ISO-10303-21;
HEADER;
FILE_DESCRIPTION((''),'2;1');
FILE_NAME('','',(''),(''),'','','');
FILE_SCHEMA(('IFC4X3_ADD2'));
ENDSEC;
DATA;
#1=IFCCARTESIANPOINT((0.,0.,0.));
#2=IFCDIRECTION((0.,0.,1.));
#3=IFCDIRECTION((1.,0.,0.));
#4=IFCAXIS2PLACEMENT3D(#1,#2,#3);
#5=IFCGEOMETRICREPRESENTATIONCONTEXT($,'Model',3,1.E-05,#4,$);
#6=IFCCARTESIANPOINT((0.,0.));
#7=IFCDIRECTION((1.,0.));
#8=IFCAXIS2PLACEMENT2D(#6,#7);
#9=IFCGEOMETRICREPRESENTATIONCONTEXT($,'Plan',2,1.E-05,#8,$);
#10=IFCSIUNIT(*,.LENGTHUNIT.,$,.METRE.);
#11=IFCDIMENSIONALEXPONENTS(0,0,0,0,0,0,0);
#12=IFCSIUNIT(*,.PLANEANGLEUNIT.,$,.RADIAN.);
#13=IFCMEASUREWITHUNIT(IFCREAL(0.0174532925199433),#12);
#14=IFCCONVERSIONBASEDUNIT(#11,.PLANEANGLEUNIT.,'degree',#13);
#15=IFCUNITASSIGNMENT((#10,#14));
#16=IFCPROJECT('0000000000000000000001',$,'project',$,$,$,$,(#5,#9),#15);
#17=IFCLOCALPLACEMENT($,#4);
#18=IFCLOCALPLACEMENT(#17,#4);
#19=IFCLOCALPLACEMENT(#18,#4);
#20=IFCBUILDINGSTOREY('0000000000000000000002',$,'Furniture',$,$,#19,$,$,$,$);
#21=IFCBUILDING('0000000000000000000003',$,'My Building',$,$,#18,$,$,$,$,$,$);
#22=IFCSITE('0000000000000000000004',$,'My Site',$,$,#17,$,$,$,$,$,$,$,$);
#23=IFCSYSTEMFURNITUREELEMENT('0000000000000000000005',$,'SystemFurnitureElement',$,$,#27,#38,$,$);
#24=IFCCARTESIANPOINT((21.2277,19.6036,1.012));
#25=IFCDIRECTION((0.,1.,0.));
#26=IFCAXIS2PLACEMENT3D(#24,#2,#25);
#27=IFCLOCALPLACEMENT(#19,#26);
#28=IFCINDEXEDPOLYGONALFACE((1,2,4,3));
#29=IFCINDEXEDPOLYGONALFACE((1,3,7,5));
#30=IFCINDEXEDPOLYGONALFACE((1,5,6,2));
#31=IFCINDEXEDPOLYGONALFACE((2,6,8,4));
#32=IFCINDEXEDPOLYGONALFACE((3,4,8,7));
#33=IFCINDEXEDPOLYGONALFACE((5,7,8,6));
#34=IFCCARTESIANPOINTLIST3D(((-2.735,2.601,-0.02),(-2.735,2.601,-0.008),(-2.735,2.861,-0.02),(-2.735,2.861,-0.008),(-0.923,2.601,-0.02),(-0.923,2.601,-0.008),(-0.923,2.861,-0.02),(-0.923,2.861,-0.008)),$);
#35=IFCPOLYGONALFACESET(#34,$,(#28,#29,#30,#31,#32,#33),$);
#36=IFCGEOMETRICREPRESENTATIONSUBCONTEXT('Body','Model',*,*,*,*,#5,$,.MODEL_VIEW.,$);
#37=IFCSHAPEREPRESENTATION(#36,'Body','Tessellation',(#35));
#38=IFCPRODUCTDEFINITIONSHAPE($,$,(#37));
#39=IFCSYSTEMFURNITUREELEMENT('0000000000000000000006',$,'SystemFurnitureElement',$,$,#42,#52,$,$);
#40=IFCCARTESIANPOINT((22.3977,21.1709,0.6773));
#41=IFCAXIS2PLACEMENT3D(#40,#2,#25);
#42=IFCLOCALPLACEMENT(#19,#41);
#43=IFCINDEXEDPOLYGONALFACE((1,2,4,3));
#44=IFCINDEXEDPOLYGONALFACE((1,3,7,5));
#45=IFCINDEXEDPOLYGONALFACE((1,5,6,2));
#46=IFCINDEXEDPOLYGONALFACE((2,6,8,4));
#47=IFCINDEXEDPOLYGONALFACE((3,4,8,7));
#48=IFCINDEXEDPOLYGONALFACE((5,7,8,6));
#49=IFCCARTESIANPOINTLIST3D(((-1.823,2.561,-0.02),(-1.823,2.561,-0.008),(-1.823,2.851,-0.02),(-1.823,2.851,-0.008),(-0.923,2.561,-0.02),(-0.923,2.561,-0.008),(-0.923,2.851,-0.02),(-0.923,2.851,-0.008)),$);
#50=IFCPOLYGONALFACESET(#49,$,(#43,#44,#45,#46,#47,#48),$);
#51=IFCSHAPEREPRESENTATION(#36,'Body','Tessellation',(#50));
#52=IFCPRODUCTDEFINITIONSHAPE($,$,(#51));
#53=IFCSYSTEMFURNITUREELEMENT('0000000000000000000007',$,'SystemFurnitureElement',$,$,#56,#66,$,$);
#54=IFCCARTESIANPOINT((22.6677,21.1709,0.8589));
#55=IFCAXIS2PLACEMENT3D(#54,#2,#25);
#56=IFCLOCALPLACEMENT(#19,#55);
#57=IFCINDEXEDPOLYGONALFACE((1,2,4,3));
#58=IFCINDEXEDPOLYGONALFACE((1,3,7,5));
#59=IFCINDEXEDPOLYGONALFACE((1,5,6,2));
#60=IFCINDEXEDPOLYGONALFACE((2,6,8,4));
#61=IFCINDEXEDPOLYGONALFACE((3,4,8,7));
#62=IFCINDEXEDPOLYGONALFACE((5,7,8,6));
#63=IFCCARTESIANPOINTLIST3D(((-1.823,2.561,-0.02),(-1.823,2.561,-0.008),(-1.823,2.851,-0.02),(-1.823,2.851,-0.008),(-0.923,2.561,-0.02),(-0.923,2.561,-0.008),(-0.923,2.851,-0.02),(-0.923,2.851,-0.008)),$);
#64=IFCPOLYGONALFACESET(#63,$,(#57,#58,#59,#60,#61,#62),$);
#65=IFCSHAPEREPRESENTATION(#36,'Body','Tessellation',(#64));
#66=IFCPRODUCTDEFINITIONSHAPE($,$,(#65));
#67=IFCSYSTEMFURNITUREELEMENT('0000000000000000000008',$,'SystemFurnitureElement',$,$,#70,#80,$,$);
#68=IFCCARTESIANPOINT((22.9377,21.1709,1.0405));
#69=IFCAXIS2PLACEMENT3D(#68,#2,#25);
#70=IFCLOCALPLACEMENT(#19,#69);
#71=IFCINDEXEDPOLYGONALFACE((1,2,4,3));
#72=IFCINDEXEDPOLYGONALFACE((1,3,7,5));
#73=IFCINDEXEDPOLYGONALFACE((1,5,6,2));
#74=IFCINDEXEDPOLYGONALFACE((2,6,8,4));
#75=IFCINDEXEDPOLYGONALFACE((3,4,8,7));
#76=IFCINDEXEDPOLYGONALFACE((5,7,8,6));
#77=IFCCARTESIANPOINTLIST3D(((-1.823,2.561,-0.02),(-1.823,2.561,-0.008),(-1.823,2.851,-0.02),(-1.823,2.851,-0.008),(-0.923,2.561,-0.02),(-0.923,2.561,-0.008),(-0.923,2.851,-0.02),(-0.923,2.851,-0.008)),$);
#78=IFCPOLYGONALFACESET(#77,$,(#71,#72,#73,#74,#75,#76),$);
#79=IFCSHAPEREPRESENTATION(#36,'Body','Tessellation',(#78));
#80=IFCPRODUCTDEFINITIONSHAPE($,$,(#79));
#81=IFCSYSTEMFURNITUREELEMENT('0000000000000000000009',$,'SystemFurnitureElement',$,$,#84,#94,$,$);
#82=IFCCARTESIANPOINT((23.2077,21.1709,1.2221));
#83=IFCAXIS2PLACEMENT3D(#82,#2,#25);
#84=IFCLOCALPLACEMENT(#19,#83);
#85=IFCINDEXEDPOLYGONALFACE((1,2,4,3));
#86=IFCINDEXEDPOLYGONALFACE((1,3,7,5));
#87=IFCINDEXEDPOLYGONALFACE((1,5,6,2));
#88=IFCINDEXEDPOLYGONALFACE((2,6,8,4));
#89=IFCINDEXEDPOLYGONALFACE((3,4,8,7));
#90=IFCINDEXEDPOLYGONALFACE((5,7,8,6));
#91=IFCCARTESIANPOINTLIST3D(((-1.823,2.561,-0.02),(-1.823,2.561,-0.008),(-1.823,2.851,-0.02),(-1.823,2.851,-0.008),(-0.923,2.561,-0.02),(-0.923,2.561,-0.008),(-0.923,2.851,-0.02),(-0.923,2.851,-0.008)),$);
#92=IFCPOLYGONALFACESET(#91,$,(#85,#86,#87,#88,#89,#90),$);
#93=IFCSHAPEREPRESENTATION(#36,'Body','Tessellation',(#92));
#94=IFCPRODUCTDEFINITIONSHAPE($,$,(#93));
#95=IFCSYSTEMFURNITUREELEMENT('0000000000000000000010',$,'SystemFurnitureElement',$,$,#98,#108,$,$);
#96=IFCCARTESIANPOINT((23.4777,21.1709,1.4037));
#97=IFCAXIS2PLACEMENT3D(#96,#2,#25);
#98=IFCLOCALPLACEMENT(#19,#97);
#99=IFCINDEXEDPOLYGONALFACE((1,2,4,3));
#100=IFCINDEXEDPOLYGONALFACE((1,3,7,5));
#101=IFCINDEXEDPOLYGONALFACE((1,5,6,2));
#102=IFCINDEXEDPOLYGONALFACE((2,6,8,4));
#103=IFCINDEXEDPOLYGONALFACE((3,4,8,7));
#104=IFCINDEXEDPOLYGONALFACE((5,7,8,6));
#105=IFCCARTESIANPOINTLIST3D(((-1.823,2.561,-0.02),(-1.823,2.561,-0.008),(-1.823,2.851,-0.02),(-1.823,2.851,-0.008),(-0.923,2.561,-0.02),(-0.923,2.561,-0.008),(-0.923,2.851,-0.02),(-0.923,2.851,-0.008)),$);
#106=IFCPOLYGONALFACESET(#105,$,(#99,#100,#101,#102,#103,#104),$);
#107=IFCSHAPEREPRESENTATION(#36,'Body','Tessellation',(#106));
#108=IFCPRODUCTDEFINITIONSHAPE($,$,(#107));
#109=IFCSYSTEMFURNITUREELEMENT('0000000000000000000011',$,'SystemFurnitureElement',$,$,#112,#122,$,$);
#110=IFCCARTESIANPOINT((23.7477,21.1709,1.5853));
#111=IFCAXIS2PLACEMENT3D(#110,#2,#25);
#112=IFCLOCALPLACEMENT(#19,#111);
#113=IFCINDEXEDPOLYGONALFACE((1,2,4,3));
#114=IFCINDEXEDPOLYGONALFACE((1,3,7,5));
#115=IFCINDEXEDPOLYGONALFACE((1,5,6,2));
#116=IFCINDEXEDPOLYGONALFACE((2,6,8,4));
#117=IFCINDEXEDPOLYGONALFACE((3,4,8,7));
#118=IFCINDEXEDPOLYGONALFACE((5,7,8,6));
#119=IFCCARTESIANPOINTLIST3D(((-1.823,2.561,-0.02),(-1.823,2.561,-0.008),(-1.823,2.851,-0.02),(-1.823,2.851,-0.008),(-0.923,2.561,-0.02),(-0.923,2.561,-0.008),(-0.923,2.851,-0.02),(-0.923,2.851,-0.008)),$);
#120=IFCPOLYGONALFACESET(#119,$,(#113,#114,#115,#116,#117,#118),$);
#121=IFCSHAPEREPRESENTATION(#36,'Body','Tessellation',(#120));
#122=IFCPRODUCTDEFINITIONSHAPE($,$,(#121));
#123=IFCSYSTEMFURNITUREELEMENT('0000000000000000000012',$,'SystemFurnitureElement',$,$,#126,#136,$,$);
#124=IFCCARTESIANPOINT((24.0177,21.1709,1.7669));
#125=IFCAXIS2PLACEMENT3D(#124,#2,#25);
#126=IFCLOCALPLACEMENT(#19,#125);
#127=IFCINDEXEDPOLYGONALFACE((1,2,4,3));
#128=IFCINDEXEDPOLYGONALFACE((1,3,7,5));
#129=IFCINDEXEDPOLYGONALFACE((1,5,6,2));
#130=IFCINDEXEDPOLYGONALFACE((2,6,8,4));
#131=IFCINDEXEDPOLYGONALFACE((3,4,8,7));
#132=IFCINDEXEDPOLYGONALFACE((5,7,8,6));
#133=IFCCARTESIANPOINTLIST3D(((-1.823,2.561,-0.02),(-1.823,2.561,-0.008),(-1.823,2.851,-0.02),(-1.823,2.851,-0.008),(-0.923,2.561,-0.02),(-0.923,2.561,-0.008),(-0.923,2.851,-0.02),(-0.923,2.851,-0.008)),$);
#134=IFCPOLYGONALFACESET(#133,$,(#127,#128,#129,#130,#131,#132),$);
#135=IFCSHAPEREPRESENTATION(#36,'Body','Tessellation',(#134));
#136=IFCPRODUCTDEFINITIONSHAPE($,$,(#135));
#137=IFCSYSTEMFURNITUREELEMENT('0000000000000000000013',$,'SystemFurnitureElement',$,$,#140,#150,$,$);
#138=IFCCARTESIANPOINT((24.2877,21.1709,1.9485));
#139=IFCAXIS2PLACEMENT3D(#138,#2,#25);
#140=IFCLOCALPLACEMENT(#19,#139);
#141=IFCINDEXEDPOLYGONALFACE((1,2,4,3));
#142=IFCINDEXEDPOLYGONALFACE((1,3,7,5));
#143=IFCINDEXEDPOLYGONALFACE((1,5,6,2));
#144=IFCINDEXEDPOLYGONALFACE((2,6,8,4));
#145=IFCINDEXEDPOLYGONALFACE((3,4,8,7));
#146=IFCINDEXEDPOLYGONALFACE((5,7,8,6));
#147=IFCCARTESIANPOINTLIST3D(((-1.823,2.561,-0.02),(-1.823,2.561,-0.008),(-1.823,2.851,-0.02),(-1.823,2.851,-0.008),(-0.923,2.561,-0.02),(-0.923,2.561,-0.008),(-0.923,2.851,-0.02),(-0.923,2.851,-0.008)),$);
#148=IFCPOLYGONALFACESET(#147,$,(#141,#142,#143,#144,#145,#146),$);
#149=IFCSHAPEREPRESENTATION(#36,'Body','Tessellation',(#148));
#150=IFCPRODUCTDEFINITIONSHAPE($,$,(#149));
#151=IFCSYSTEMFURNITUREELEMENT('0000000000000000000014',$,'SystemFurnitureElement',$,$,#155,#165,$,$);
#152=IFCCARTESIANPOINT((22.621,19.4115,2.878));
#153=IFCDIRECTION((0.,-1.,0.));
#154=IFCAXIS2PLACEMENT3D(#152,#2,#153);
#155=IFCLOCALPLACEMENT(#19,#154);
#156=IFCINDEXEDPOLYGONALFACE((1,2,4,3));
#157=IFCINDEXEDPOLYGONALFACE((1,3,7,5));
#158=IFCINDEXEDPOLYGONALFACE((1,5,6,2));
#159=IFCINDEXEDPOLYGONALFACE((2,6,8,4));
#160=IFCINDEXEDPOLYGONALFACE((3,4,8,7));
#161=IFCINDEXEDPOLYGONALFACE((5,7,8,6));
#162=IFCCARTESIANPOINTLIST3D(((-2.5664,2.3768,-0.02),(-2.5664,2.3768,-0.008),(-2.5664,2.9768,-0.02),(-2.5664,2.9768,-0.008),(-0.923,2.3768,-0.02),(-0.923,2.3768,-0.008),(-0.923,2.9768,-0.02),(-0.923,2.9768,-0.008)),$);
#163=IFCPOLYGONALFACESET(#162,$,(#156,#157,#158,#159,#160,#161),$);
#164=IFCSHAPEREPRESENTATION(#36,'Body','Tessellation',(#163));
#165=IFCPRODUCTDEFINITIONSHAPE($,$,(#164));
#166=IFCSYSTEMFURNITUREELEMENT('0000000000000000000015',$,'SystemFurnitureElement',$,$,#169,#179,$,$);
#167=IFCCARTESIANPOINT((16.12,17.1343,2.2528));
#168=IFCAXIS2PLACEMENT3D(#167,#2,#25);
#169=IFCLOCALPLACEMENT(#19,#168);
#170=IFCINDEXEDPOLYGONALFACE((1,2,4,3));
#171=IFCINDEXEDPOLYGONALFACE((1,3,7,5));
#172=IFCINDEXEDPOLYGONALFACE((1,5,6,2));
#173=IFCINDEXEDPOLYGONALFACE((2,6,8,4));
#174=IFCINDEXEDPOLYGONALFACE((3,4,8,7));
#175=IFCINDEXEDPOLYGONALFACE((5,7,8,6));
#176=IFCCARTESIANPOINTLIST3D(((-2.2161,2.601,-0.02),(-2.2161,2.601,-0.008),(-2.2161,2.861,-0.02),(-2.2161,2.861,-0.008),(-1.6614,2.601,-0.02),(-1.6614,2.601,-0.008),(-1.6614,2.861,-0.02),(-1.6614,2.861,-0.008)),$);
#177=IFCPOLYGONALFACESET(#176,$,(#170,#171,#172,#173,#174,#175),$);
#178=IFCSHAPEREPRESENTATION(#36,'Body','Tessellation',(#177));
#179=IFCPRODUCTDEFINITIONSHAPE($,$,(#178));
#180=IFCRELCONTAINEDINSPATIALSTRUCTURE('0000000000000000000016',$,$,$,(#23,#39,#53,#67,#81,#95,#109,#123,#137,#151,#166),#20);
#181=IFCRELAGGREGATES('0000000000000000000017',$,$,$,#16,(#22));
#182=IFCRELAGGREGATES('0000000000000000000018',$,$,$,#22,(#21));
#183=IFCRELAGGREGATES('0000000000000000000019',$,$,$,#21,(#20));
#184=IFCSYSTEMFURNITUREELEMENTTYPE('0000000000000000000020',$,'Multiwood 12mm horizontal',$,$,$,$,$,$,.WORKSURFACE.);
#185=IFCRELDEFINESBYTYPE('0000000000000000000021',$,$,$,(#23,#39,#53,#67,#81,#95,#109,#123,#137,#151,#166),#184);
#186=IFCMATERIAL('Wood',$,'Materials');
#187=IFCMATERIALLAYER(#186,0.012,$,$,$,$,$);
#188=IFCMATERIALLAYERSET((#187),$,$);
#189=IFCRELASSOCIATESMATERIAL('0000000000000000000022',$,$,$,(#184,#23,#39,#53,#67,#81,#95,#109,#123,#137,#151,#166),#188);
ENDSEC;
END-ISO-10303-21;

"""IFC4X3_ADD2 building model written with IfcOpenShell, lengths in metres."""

from ifc_helpers import new_model, entity, si_unit, converted_unit, frame, origin_with_axes, origin_2d_with_axis, place, context, subcontext, project, spatial, indexed_curve, outline, extrude, material, layer, layer_set, layer_usage, type_object, element, save


model = new_model("IFC4X3_ADD2")

# Units and contexts
model_context = context("Model", 3, precision=1e-05, world=origin_with_axes())
plan_context = context("Plan", 2, precision=1e-05, world=origin_2d_with_axis())
body_context = subcontext(model_context, "Body", "Model", "MODEL_VIEW")
ifc_project = project(units=[si_unit("LENGTHUNIT", "METRE"), converted_unit("PLANEANGLEUNIT", "degree", entity("IfcReal", 0.0174532925199433), si_unit("PLANEANGLEUNIT", "RADIAN"), dimensions=[0, 0, 0, 0, 0, 0, 0])], contexts=[model_context, plan_context])

# Site, building, storey
site_placement = place(None, origin_with_axes())
site = spatial("IfcSite", under=ifc_project, at=site_placement, Name="My Site")
building_placement = place(site_placement, origin_with_axes())
building = spatial("IfcBuilding", under=site, at=building_placement, Name="My Building")
storey_placement = place(building_placement, origin_with_axes())
storey = spatial("IfcBuildingStorey", under=building, at=storey_placement, Name="Furniture")

# System furniture elements
ifc_material = material(Name="Wood", Category="Materials")
ifc_layer_1 = layer(ifc_material, 0.012)
ifc_layer_set_1 = layer_set([ifc_layer_1])
ifc_layer_usage_1 = layer_usage(ifc_layer_set_1, "AXIS3", "POSITIVE", -0.02)
system_furniture_element_type_1 = type_object("IfcSystemFurnitureElementType", Name="Multiwood 12mm horizontal", PredefinedType="WORKSURFACE", material=ifc_layer_set_1)
system_furniture_element_1_placement = place(storey_placement, frame((21.2277, 19.6036, 1.012), z_axis=(0.0, 0.0, 1.0), x_axis=(0.0, 1.0, 0.0)))
element("IfcSystemFurnitureElement", 1, at=system_furniture_element_1_placement, inside=storey, type_object=system_furniture_element_type_1, material=ifc_layer_usage_1, Name="SystemFurnitureElement", context=body_context, shape_type="SweptSolid", body=[
    extrude(outline(indexed_curve([(-2.735, 2.861), (-2.735, 2.601), (-0.923, 2.601), (-0.923, 2.861), (-2.735, 2.861)])), frame((0.0, 0.0, -0.02), z_axis=(0.0, 0.0, 1.0), x_axis=(1.0, 0.0, 0.0)), (0.0, 0.0, 1.0), 0.012),
])
ifc_layer_usage_2 = layer_usage(ifc_layer_set_1, "AXIS3", "POSITIVE", -0.02)
system_furniture_element_2_placement = place(storey_placement, frame((22.3977, 21.1709, 0.6773), z_axis=(0.0, 0.0, 1.0), x_axis=(0.0, 1.0, 0.0)))
element("IfcSystemFurnitureElement", 2, at=system_furniture_element_2_placement, inside=storey, type_object=system_furniture_element_type_1, material=ifc_layer_usage_2, Name="SystemFurnitureElement", context=body_context, shape_type="SweptSolid", body=[
    extrude(outline(indexed_curve([(-0.923, 2.851), (-0.923, 2.561), (-1.823, 2.561), (-1.823, 2.851), (-0.923, 2.851)])), frame((0.0, 0.0, -0.02), z_axis=(0.0, 0.0, 1.0), x_axis=(1.0, 0.0, 0.0)), (0.0, 0.0, 1.0), 0.012),
])
ifc_layer_usage_3 = layer_usage(ifc_layer_set_1, "AXIS3", "POSITIVE", -0.02)
system_furniture_element_3_placement = place(storey_placement, frame((22.6677, 21.1709, 0.8589), z_axis=(0.0, 0.0, 1.0), x_axis=(0.0, 1.0, 0.0)))
element("IfcSystemFurnitureElement", 3, at=system_furniture_element_3_placement, inside=storey, type_object=system_furniture_element_type_1, material=ifc_layer_usage_3, Name="SystemFurnitureElement", context=body_context, shape_type="SweptSolid", body=[
    extrude(outline(indexed_curve([(-0.923, 2.851), (-0.923, 2.561), (-1.823, 2.561), (-1.823, 2.851), (-0.923, 2.851)])), frame((0.0, 0.0, -0.02), z_axis=(0.0, 0.0, 1.0), x_axis=(1.0, 0.0, 0.0)), (0.0, 0.0, 1.0), 0.012),
])
ifc_layer_usage_4 = layer_usage(ifc_layer_set_1, "AXIS3", "POSITIVE", -0.02)
system_furniture_element_4_placement = place(storey_placement, frame((22.9377, 21.1709, 1.0405), z_axis=(0.0, 0.0, 1.0), x_axis=(0.0, 1.0, 0.0)))
element("IfcSystemFurnitureElement", 4, at=system_furniture_element_4_placement, inside=storey, type_object=system_furniture_element_type_1, material=ifc_layer_usage_4, Name="SystemFurnitureElement", context=body_context, shape_type="SweptSolid", body=[
    extrude(outline(indexed_curve([(-0.923, 2.851), (-0.923, 2.561), (-1.823, 2.561), (-1.823, 2.851), (-0.923, 2.851)])), frame((0.0, 0.0, -0.02), z_axis=(0.0, 0.0, 1.0), x_axis=(1.0, 0.0, 0.0)), (0.0, 0.0, 1.0), 0.012),
])
ifc_layer_usage_5 = layer_usage(ifc_layer_set_1, "AXIS3", "POSITIVE", -0.02)
system_furniture_element_5_placement = place(storey_placement, frame((23.2077, 21.1709, 1.2221), z_axis=(0.0, 0.0, 1.0), x_axis=(0.0, 1.0, 0.0)))
element("IfcSystemFurnitureElement", 5, at=system_furniture_element_5_placement, inside=storey, type_object=system_furniture_element_type_1, material=ifc_layer_usage_5, Name="SystemFurnitureElement", context=body_context, shape_type="SweptSolid", body=[
    extrude(outline(indexed_curve([(-0.923, 2.851), (-0.923, 2.561), (-1.823, 2.561), (-1.823, 2.851), (-0.923, 2.851)])), frame((0.0, 0.0, -0.02), z_axis=(0.0, 0.0, 1.0), x_axis=(1.0, 0.0, 0.0)), (0.0, 0.0, 1.0), 0.012),
])
ifc_layer_usage_6 = layer_usage(ifc_layer_set_1, "AXIS3", "POSITIVE", -0.02)
system_furniture_element_6_placement = place(storey_placement, frame((23.4777, 21.1709, 1.4037), z_axis=(0.0, 0.0, 1.0), x_axis=(0.0, 1.0, 0.0)))
element("IfcSystemFurnitureElement", 6, at=system_furniture_element_6_placement, inside=storey, type_object=system_furniture_element_type_1, material=ifc_layer_usage_6, Name="SystemFurnitureElement", context=body_context, shape_type="SweptSolid", body=[
    extrude(outline(indexed_curve([(-0.923, 2.851), (-0.923, 2.561), (-1.823, 2.561), (-1.823, 2.851), (-0.923, 2.851)])), frame((0.0, 0.0, -0.02), z_axis=(0.0, 0.0, 1.0), x_axis=(1.0, 0.0, 0.0)), (0.0, 0.0, 1.0), 0.012),
])
ifc_layer_usage_7 = layer_usage(ifc_layer_set_1, "AXIS3", "POSITIVE", -0.02)
system_furniture_element_7_placement = place(storey_placement, frame((23.7477, 21.1709, 1.5853), z_axis=(0.0, 0.0, 1.0), x_axis=(0.0, 1.0, 0.0)))
element("IfcSystemFurnitureElement", 7, at=system_furniture_element_7_placement, inside=storey, type_object=system_furniture_element_type_1, material=ifc_layer_usage_7, Name="SystemFurnitureElement", context=body_context, shape_type="SweptSolid", body=[
    extrude(outline(indexed_curve([(-0.923, 2.851), (-0.923, 2.561), (-1.823, 2.561), (-1.823, 2.851), (-0.923, 2.851)])), frame((0.0, 0.0, -0.02), z_axis=(0.0, 0.0, 1.0), x_axis=(1.0, 0.0, 0.0)), (0.0, 0.0, 1.0), 0.012),
])
ifc_layer_usage_8 = layer_usage(ifc_layer_set_1, "AXIS3", "POSITIVE", -0.02)
system_furniture_element_8_placement = place(storey_placement, frame((24.0177, 21.1709, 1.7669), z_axis=(0.0, 0.0, 1.0), x_axis=(0.0, 1.0, 0.0)))
element("IfcSystemFurnitureElement", 8, at=system_furniture_element_8_placement, inside=storey, type_object=system_furniture_element_type_1, material=ifc_layer_usage_8, Name="SystemFurnitureElement", context=body_context, shape_type="SweptSolid", body=[
    extrude(outline(indexed_curve([(-0.923, 2.851), (-0.923, 2.561), (-1.823, 2.561), (-1.823, 2.851), (-0.923, 2.851)])), frame((0.0, 0.0, -0.02), z_axis=(0.0, 0.0, 1.0), x_axis=(1.0, 0.0, 0.0)), (0.0, 0.0, 1.0), 0.012),
])
ifc_layer_usage_9 = layer_usage(ifc_layer_set_1, "AXIS3", "POSITIVE", -0.02)
system_furniture_element_9_placement = place(storey_placement, frame((24.2877, 21.1709, 1.9485), z_axis=(0.0, 0.0, 1.0), x_axis=(0.0, 1.0, 0.0)))
element("IfcSystemFurnitureElement", 9, at=system_furniture_element_9_placement, inside=storey, type_object=system_furniture_element_type_1, material=ifc_layer_usage_9, Name="SystemFurnitureElement", context=body_context, shape_type="SweptSolid", body=[
    extrude(outline(indexed_curve([(-0.923, 2.851), (-0.923, 2.561), (-1.823, 2.561), (-1.823, 2.851), (-0.923, 2.851)])), frame((0.0, 0.0, -0.02), z_axis=(0.0, 0.0, 1.0), x_axis=(1.0, 0.0, 0.0)), (0.0, 0.0, 1.0), 0.012),
])
ifc_layer_usage_10 = layer_usage(ifc_layer_set_1, "AXIS3", "POSITIVE", -0.02)
system_furniture_element_10_placement = place(storey_placement, frame((22.621, 19.4115, 2.878), z_axis=(0.0, 0.0, 1.0), x_axis=(0.0, -1.0, 0.0)))
element("IfcSystemFurnitureElement", 10, at=system_furniture_element_10_placement, inside=storey, type_object=system_furniture_element_type_1, material=ifc_layer_usage_10, Name="SystemFurnitureElement", context=body_context, shape_type="SweptSolid", body=[
    extrude(outline(indexed_curve([(-0.923, 2.9768), (-0.923, 2.3768), (-2.5664, 2.3768), (-2.5664, 2.9768), (-0.923, 2.9768)])), frame((0.0, 0.0, -0.02), z_axis=(0.0, 0.0, 1.0), x_axis=(1.0, 0.0, 0.0)), (0.0, 0.0, 1.0), 0.012),
])
ifc_layer_usage_11 = layer_usage(ifc_layer_set_1, "AXIS3", "POSITIVE", -0.02)
system_furniture_element_11_placement = place(storey_placement, frame((16.12, 17.1343, 2.2528), z_axis=(0.0, 0.0, 1.0), x_axis=(0.0, 1.0, 0.0)))
element("IfcSystemFurnitureElement", 11, at=system_furniture_element_11_placement, inside=storey, type_object=system_furniture_element_type_1, material=ifc_layer_usage_11, Name="SystemFurnitureElement", context=body_context, shape_type="SweptSolid", body=[
    extrude(outline(indexed_curve([(-2.2161, 2.861), (-2.2161, 2.601), (-1.6614, 2.601), (-1.6614, 2.861), (-2.2161, 2.861)])), frame((0.0, 0.0, -0.02), z_axis=(0.0, 0.0, 1.0), x_axis=(1.0, 0.0, 0.0)), (0.0, 0.0, 1.0), 0.012),
])

save(model, "model.ifc")
